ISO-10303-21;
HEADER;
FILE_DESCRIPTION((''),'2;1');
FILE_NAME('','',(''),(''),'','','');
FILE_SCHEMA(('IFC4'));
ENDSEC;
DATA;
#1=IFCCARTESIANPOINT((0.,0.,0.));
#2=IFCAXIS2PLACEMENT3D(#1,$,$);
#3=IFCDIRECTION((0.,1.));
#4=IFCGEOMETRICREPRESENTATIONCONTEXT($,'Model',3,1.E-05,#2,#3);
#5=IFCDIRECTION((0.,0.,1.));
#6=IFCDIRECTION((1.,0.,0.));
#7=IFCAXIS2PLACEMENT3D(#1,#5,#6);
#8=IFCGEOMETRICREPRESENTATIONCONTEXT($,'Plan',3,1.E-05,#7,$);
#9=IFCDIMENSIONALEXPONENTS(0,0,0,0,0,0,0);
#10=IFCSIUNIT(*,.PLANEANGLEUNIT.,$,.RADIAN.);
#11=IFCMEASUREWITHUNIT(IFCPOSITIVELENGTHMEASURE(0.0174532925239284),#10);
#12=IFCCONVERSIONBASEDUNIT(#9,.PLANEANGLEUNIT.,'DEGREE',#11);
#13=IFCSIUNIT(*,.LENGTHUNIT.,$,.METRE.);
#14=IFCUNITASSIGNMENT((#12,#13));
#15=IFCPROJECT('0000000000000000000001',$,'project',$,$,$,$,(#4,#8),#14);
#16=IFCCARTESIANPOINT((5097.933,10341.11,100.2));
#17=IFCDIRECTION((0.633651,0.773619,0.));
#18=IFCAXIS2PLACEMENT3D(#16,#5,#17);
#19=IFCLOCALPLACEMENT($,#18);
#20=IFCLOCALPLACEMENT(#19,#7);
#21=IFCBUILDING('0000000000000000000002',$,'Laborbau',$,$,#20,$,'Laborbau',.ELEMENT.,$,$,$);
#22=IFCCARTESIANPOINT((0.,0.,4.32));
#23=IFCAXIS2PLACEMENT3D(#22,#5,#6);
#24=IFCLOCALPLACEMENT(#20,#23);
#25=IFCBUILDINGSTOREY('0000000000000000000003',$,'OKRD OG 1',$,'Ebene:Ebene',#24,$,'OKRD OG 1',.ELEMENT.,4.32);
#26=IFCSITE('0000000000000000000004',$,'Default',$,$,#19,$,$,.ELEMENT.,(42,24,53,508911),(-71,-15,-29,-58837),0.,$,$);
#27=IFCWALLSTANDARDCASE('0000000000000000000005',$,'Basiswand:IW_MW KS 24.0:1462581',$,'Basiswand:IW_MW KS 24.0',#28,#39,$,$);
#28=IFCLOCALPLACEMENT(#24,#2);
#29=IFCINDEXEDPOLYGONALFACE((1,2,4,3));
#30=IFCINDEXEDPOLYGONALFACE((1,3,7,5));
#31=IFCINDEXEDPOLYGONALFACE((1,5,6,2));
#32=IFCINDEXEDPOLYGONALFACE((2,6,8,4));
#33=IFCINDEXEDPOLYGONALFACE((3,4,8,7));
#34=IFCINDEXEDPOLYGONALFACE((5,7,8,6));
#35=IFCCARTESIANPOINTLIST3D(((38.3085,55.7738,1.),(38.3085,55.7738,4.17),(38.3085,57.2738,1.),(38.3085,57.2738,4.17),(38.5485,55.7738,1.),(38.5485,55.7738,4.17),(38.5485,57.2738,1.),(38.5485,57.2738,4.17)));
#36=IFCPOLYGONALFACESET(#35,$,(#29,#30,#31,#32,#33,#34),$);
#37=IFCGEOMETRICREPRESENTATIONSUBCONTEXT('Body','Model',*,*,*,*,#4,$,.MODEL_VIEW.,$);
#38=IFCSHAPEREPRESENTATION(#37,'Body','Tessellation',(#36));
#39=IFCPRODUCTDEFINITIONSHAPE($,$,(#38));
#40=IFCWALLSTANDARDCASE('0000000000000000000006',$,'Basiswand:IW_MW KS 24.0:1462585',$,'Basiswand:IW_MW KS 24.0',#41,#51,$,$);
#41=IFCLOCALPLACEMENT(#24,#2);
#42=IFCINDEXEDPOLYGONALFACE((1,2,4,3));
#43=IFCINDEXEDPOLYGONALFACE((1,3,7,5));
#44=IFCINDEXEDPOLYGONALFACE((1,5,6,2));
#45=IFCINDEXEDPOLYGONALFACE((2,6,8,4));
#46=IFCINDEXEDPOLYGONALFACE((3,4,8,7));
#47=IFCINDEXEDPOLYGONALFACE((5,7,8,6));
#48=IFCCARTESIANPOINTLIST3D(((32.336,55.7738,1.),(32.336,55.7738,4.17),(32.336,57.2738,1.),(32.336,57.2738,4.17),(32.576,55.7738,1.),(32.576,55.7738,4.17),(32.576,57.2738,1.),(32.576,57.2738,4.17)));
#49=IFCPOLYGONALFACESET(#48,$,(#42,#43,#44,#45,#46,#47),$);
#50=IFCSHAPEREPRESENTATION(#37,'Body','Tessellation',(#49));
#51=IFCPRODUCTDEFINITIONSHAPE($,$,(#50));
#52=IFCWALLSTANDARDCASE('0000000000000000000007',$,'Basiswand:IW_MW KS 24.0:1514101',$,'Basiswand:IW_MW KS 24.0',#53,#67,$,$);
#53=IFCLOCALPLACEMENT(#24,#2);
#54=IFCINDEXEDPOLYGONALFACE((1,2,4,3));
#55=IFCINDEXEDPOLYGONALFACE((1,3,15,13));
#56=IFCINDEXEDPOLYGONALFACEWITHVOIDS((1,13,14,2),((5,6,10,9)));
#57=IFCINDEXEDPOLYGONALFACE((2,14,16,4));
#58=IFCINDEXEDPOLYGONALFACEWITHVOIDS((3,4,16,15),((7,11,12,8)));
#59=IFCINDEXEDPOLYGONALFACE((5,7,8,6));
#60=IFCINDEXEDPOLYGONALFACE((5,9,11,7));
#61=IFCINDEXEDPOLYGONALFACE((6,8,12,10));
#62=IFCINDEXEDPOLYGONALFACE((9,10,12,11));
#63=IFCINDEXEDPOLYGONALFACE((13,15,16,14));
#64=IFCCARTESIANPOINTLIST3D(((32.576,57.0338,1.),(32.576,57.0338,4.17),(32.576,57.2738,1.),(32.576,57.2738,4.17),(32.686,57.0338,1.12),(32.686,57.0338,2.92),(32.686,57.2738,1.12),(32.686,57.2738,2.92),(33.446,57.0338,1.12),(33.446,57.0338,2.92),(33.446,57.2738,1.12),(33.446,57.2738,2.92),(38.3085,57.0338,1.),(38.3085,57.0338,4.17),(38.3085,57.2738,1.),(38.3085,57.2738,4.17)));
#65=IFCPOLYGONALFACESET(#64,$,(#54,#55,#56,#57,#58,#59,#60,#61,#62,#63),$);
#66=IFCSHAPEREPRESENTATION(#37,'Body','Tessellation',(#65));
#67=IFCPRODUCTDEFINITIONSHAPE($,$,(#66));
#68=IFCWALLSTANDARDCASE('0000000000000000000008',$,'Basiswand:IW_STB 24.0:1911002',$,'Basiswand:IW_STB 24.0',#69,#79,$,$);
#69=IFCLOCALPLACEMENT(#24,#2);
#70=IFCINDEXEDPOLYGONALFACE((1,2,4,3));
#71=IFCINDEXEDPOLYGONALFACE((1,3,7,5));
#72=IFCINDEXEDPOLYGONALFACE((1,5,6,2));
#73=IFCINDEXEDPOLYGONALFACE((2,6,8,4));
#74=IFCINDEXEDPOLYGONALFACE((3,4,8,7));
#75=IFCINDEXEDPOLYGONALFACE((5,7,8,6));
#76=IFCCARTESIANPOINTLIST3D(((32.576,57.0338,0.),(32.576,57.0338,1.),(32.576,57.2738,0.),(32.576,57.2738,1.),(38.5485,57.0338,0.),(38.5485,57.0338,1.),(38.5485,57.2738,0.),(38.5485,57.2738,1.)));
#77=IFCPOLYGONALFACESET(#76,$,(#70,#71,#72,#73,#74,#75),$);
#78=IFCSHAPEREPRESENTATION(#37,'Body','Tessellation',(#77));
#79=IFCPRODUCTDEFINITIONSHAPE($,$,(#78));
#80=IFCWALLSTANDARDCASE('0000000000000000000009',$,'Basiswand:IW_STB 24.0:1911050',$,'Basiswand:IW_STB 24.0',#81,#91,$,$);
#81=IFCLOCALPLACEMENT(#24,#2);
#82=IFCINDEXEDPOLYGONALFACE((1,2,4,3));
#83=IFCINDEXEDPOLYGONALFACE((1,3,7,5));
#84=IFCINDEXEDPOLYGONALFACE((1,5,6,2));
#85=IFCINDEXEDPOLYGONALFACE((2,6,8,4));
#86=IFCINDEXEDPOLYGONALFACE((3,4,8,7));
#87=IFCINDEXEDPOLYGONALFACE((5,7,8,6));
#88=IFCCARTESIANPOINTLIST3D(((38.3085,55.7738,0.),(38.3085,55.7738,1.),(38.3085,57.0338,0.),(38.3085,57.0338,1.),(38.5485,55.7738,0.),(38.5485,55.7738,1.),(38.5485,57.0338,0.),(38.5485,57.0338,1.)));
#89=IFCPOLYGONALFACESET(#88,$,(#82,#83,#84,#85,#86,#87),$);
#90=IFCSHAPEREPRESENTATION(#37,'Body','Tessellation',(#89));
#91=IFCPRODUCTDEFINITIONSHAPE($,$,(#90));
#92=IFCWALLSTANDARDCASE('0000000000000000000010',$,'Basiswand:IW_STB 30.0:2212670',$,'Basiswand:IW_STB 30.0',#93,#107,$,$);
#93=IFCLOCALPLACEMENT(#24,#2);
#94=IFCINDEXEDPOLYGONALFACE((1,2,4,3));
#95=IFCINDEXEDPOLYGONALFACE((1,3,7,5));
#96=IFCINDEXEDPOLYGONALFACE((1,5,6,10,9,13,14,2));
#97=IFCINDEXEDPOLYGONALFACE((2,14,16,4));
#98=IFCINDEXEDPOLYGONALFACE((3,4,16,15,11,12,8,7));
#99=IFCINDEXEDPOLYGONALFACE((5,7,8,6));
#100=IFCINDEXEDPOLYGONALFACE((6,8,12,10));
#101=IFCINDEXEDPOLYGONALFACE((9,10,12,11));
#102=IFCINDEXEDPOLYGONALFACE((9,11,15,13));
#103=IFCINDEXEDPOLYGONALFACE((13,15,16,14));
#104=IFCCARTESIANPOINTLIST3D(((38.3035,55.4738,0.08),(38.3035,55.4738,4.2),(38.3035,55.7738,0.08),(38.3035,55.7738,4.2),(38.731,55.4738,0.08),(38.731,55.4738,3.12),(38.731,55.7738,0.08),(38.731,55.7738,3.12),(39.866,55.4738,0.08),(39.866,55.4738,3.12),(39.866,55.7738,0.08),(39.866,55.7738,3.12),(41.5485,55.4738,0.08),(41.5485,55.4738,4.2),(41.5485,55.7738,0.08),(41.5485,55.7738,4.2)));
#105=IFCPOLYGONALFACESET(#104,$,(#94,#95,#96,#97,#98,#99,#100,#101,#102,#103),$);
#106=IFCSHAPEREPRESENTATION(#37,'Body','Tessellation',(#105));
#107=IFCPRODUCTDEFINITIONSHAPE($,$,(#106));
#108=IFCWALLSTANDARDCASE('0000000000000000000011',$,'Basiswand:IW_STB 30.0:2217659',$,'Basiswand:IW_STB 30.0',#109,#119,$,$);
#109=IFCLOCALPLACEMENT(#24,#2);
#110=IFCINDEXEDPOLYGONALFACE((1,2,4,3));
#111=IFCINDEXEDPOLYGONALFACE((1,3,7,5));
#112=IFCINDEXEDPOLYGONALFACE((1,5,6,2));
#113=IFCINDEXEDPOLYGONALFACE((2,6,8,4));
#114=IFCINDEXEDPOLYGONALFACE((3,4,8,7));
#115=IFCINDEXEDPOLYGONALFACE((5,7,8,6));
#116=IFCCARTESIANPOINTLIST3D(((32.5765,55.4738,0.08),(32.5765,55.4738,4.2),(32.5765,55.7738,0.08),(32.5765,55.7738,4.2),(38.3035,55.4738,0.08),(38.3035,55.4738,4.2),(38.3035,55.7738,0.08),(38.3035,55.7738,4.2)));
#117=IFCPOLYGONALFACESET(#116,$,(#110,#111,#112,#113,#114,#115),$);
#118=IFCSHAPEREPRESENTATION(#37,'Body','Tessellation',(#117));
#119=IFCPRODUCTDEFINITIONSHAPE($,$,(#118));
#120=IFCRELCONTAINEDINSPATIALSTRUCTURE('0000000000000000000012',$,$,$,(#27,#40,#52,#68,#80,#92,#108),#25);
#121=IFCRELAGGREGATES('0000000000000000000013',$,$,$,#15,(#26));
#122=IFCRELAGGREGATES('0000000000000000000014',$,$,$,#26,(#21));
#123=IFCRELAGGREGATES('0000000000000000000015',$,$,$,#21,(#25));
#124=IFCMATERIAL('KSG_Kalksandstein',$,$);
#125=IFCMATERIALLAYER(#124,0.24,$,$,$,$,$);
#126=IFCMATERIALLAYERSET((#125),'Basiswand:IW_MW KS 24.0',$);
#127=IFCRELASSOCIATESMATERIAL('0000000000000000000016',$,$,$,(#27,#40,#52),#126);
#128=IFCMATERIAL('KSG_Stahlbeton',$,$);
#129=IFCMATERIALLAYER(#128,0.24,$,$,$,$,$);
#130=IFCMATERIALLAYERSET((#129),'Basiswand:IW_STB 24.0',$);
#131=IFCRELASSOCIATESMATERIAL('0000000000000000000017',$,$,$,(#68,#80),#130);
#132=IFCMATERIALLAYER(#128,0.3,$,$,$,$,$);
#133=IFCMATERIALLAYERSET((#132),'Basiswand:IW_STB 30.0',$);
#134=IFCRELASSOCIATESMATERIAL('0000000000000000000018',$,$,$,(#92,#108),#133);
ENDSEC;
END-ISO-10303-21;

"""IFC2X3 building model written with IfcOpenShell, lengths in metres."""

from ifc_helpers import new_model, entity, si_unit, converted_unit, direction, frame, frame_2d, origin, origin_with_axes, place, context, subcontext, project, spatial, rectangle, extrude, material, layer, layer_set, layer_usage, element, save


model = new_model("IFC2X3")

# Units and contexts
model_context = context("Model", 3, precision=1e-05, world=origin(), true_north=direction((0.0, 1.0)))
plan_context = context("Plan", 3, precision=1e-05, world=origin_with_axes())
body_context = subcontext(model_context, "Body", "Model", "MODEL_VIEW")
ifc_project = project(units=[converted_unit("PLANEANGLEUNIT", "DEGREE", entity("IfcPositiveLengthMeasure", 0.0174532925239284), si_unit("PLANEANGLEUNIT", "RADIAN"), dimensions=[0, 0, 0, 0, 0, 0, 0]), si_unit("LENGTHUNIT", "METRE")], contexts=[model_context, plan_context])

# Site, building, storey
site_placement = place(None, frame((5097.933, 10341.11, 100.2), z_axis=(0.0, 0.0, 1.0), x_axis=(0.633651, 0.773619, 0.0)))
site = spatial("IfcSite", under=ifc_project, at=site_placement, Name="Default", CompositionType="ELEMENT", RefLatitude=(42, 24, 53, 508911), RefLongitude=(-71, -15, -29, -58837), RefElevation=0.0)
building_placement = place(site_placement, origin_with_axes())
building = spatial("IfcBuilding", under=site, at=building_placement, Name="Laborbau", LongName="Laborbau", CompositionType="ELEMENT")
storey_placement = place(building_placement, frame((0.0, 0.0, 4.32), z_axis=(0.0, 0.0, 1.0), x_axis=(1.0, 0.0, 0.0)))
storey = spatial("IfcBuildingStorey", under=building, at=storey_placement, Name="OKRD OG 1", ObjectType="Ebene:Ebene", LongName="OKRD OG 1", CompositionType="ELEMENT", Elevation=4.32)

# Walls
ifc_material_1 = material(Name="KSG_Kalksandstein")
ifc_layer_1 = layer(ifc_material_1, 0.24)
ifc_layer_set_1 = layer_set([ifc_layer_1], Name="Basiswand:IW_MW KS 24.0")
ifc_layer_usage_1 = layer_usage(ifc_layer_set_1, "AXIS2", "POSITIVE", -0.12)
wall_1_placement = place(storey_placement, frame((38.4285, 55.7738, 1.0), z_axis=(0.0, 0.0, 1.0), x_axis=(0.0, 1.0, 0.0)))
element("IfcWallStandardCase", 1, at=wall_1_placement, inside=storey, material=ifc_layer_usage_1, Name="Basiswand:IW_MW KS 24.0:1462581", ObjectType="Basiswand:IW_MW KS 24.0", context=body_context, shape_type="SweptSolid", body=[
    extrude(rectangle(XDim=1.5, YDim=0.24, at=frame_2d((0.75, 0.0), x_axis=(-1.0, 0.0))), origin(), (0.0, 0.0, 1.0), 3.17),
])
ifc_layer_usage_2 = layer_usage(ifc_layer_set_1, "AXIS2", "POSITIVE", -0.12)
wall_2_placement = place(storey_placement, frame((32.456, 57.2738, 1.0), z_axis=(0.0, 0.0, 1.0), x_axis=(0.0, -1.0, 0.0)))
element("IfcWallStandardCase", 2, at=wall_2_placement, inside=storey, material=ifc_layer_usage_2, Name="Basiswand:IW_MW KS 24.0:1462585", ObjectType="Basiswand:IW_MW KS 24.0", context=body_context, shape_type="SweptSolid", body=[
    extrude(rectangle(XDim=1.5, YDim=0.24, at=frame_2d((0.75, 0.0), x_axis=(-1.0, 0.0))), origin(), (0.0, 0.0, 1.0), 3.17),
])

# Wall, openings
ifc_layer_usage_3 = layer_usage(ifc_layer_set_1, "AXIS2", "NEGATIVE", 0.12)
wall_3_placement = place(storey_placement, frame((32.576, 57.1538, 1.0), z_axis=(0.0, 0.0, 1.0), x_axis=(1.0, 0.0, 0.0)))
wall_3 = element("IfcWallStandardCase", 3, at=wall_3_placement, inside=storey, material=ifc_layer_usage_3, Name="Basiswand:IW_MW KS 24.0:1514101", ObjectType="Basiswand:IW_MW KS 24.0", context=body_context, shape_type="SweptSolid", body=[
    extrude(rectangle(XDim=5.7325, YDim=0.24, at=frame_2d((2.8662, 0.0), x_axis=(-1.0, 0.0))), origin(), (0.0, 0.0, 1.0), 3.17),
])
opening_1_placement = place(wall_3_placement, frame((-32.576, -57.1538, -1.0), z_axis=(0.0, 0.0, 1.0), x_axis=(1.0, 0.0, 0.0)))
element("IfcOpeningElement", 4, at=opening_1_placement, cuts=wall_3, ObjectType="Opening", context=body_context, shape_type="SweptSolid", body=[
    extrude(rectangle(XDim=1.8, YDim=0.76, at=frame_2d((0.0, 0.0), x_axis=(0.0, 1.0))), frame((33.066, 55.5098, 2.02), z_axis=(0.0, 1.0, 0.0), x_axis=(-1.0, 0.0, 0.0)), (0.0, 0.0, 1.0), 3.048),
])
opening_2_placement = place(wall_3_placement, frame((0.11, -0.12, 0.12), z_axis=(0.0, 0.0, 1.0), x_axis=(1.0, 0.0, 0.0)))
element("IfcOpeningElement", 5, at=opening_2_placement, cuts=wall_3, ObjectType="Opening", context=body_context, shape_type="SweptSolid", body=[
    extrude(rectangle(XDim=1.8, YDim=0.76, at=frame_2d((0.9, 0.38), x_axis=(1.0, 0.0))), frame((0.0, 0.0, 0.0), z_axis=(0.0, 1.0, 0.0), x_axis=(0.0, 0.0, 1.0)), (0.0, 0.0, 1.0), 0.24),
])

# Walls
ifc_material_2 = material(Name="KSG_Stahlbeton")
ifc_layer_2 = layer(ifc_material_2, 0.24)
ifc_layer_set_2 = layer_set([ifc_layer_2], Name="Basiswand:IW_STB 24.0")
ifc_layer_usage_4 = layer_usage(ifc_layer_set_2, "AXIS2", "NEGATIVE", 0.12)
wall_4_placement = place(storey_placement, frame((32.576, 57.1538, 0.0), z_axis=(0.0, 0.0, 1.0), x_axis=(1.0, 0.0, 0.0)))
element("IfcWallStandardCase", 6, at=wall_4_placement, inside=storey, material=ifc_layer_usage_4, Name="Basiswand:IW_STB 24.0:1911002", ObjectType="Basiswand:IW_STB 24.0", context=body_context, shape_type="SweptSolid", body=[
    extrude(rectangle(XDim=5.9725, YDim=0.24, at=frame_2d((2.9863, 0.0), x_axis=(-1.0, 0.0))), origin(), (0.0, 0.0, 1.0), 1.0),
])
ifc_layer_usage_5 = layer_usage(ifc_layer_set_2, "AXIS2", "NEGATIVE", 0.12)
wall_5_placement = place(storey_placement, frame((38.4285, 57.0338, 0.0), z_axis=(0.0, 0.0, 1.0), x_axis=(0.0, -1.0, 0.0)))
element("IfcWallStandardCase", 7, at=wall_5_placement, inside=storey, material=ifc_layer_usage_5, Name="Basiswand:IW_STB 24.0:1911050", ObjectType="Basiswand:IW_STB 24.0", context=body_context, shape_type="SweptSolid", body=[
    extrude(rectangle(XDim=1.26, YDim=0.24, at=frame_2d((0.63, 0.0), x_axis=(-1.0, 0.0))), origin(), (0.0, 0.0, 1.0), 1.0),
])

# Wall, openings
ifc_layer_3 = layer(ifc_material_2, 0.3)
ifc_layer_set_3 = layer_set([ifc_layer_3], Name="Basiswand:IW_STB 30.0")
ifc_layer_usage_6 = layer_usage(ifc_layer_set_3, "AXIS2", "NEGATIVE", 0.15)
wall_6_placement = place(storey_placement, frame((41.5485, 55.6238, 0.08), z_axis=(0.0, 0.0, 1.0), x_axis=(-1.0, 0.0, 0.0)))
wall_6 = element("IfcWallStandardCase", 8, at=wall_6_placement, inside=storey, material=ifc_layer_usage_6, Name="Basiswand:IW_STB 30.0:2212670", ObjectType="Basiswand:IW_STB 30.0", context=body_context, shape_type="SweptSolid", body=[
    extrude(rectangle(XDim=3.245, YDim=0.3, at=frame_2d((1.6225, 0.0), x_axis=(-1.0, 0.0))), origin(), (0.0, 0.0, 1.0), 4.12),
])
opening_3_placement = place(wall_6_placement, frame((41.5485, 55.6238, -0.08), z_axis=(0.0, 0.0, 1.0), x_axis=(-1.0, 0.0, 0.0)))
element("IfcOpeningElement", 9, at=opening_3_placement, cuts=wall_6, ObjectType="Opening", context=body_context, shape_type="SweptSolid", body=[
    extrude(rectangle(XDim=3.04, YDim=1.135, at=frame_2d((0.0, 0.0), x_axis=(0.0, 1.0))), frame((39.2985, 57.2978, 1.6), z_axis=(0.0, -1.0, 0.0), x_axis=(1.0, 0.0, 0.0)), (0.0, 0.0, 1.0), 3.048),
])
opening_4_placement = place(wall_6_placement, frame((2.8175, 0.15, 0.0), z_axis=(0.0, 0.0, 1.0), x_axis=(1.0, 0.0, 0.0)))
element("IfcOpeningElement", 10, at=opening_4_placement, cuts=wall_6, ObjectType="Opening", context=body_context, shape_type="SweptSolid", body=[
    extrude(rectangle(XDim=3.04, YDim=1.135, at=frame_2d((1.52, 0.5675), x_axis=(1.0, 0.0))), frame((0.0, 0.0, 0.0), z_axis=(0.0, -1.0, 0.0), x_axis=(0.0, 0.0, 1.0)), (0.0, 0.0, 1.0), 0.3),
])

# Wall
ifc_layer_usage_7 = layer_usage(ifc_layer_set_3, "AXIS2", "NEGATIVE", 0.15)
wall_7_placement = place(storey_placement, frame((38.3035, 55.6238, 0.08), z_axis=(0.0, 0.0, 1.0), x_axis=(-1.0, 0.0, 0.0)))
element("IfcWallStandardCase", 11, at=wall_7_placement, inside=storey, material=ifc_layer_usage_7, Name="Basiswand:IW_STB 30.0:2217659", ObjectType="Basiswand:IW_STB 30.0", context=body_context, shape_type="SweptSolid", body=[
    extrude(rectangle(XDim=5.727, YDim=0.3, at=frame_2d((2.8635, 0.0), x_axis=(-1.0, 0.0))), origin(), (0.0, 0.0, 1.0), 4.12),
])

save(model, "model.ifc")
